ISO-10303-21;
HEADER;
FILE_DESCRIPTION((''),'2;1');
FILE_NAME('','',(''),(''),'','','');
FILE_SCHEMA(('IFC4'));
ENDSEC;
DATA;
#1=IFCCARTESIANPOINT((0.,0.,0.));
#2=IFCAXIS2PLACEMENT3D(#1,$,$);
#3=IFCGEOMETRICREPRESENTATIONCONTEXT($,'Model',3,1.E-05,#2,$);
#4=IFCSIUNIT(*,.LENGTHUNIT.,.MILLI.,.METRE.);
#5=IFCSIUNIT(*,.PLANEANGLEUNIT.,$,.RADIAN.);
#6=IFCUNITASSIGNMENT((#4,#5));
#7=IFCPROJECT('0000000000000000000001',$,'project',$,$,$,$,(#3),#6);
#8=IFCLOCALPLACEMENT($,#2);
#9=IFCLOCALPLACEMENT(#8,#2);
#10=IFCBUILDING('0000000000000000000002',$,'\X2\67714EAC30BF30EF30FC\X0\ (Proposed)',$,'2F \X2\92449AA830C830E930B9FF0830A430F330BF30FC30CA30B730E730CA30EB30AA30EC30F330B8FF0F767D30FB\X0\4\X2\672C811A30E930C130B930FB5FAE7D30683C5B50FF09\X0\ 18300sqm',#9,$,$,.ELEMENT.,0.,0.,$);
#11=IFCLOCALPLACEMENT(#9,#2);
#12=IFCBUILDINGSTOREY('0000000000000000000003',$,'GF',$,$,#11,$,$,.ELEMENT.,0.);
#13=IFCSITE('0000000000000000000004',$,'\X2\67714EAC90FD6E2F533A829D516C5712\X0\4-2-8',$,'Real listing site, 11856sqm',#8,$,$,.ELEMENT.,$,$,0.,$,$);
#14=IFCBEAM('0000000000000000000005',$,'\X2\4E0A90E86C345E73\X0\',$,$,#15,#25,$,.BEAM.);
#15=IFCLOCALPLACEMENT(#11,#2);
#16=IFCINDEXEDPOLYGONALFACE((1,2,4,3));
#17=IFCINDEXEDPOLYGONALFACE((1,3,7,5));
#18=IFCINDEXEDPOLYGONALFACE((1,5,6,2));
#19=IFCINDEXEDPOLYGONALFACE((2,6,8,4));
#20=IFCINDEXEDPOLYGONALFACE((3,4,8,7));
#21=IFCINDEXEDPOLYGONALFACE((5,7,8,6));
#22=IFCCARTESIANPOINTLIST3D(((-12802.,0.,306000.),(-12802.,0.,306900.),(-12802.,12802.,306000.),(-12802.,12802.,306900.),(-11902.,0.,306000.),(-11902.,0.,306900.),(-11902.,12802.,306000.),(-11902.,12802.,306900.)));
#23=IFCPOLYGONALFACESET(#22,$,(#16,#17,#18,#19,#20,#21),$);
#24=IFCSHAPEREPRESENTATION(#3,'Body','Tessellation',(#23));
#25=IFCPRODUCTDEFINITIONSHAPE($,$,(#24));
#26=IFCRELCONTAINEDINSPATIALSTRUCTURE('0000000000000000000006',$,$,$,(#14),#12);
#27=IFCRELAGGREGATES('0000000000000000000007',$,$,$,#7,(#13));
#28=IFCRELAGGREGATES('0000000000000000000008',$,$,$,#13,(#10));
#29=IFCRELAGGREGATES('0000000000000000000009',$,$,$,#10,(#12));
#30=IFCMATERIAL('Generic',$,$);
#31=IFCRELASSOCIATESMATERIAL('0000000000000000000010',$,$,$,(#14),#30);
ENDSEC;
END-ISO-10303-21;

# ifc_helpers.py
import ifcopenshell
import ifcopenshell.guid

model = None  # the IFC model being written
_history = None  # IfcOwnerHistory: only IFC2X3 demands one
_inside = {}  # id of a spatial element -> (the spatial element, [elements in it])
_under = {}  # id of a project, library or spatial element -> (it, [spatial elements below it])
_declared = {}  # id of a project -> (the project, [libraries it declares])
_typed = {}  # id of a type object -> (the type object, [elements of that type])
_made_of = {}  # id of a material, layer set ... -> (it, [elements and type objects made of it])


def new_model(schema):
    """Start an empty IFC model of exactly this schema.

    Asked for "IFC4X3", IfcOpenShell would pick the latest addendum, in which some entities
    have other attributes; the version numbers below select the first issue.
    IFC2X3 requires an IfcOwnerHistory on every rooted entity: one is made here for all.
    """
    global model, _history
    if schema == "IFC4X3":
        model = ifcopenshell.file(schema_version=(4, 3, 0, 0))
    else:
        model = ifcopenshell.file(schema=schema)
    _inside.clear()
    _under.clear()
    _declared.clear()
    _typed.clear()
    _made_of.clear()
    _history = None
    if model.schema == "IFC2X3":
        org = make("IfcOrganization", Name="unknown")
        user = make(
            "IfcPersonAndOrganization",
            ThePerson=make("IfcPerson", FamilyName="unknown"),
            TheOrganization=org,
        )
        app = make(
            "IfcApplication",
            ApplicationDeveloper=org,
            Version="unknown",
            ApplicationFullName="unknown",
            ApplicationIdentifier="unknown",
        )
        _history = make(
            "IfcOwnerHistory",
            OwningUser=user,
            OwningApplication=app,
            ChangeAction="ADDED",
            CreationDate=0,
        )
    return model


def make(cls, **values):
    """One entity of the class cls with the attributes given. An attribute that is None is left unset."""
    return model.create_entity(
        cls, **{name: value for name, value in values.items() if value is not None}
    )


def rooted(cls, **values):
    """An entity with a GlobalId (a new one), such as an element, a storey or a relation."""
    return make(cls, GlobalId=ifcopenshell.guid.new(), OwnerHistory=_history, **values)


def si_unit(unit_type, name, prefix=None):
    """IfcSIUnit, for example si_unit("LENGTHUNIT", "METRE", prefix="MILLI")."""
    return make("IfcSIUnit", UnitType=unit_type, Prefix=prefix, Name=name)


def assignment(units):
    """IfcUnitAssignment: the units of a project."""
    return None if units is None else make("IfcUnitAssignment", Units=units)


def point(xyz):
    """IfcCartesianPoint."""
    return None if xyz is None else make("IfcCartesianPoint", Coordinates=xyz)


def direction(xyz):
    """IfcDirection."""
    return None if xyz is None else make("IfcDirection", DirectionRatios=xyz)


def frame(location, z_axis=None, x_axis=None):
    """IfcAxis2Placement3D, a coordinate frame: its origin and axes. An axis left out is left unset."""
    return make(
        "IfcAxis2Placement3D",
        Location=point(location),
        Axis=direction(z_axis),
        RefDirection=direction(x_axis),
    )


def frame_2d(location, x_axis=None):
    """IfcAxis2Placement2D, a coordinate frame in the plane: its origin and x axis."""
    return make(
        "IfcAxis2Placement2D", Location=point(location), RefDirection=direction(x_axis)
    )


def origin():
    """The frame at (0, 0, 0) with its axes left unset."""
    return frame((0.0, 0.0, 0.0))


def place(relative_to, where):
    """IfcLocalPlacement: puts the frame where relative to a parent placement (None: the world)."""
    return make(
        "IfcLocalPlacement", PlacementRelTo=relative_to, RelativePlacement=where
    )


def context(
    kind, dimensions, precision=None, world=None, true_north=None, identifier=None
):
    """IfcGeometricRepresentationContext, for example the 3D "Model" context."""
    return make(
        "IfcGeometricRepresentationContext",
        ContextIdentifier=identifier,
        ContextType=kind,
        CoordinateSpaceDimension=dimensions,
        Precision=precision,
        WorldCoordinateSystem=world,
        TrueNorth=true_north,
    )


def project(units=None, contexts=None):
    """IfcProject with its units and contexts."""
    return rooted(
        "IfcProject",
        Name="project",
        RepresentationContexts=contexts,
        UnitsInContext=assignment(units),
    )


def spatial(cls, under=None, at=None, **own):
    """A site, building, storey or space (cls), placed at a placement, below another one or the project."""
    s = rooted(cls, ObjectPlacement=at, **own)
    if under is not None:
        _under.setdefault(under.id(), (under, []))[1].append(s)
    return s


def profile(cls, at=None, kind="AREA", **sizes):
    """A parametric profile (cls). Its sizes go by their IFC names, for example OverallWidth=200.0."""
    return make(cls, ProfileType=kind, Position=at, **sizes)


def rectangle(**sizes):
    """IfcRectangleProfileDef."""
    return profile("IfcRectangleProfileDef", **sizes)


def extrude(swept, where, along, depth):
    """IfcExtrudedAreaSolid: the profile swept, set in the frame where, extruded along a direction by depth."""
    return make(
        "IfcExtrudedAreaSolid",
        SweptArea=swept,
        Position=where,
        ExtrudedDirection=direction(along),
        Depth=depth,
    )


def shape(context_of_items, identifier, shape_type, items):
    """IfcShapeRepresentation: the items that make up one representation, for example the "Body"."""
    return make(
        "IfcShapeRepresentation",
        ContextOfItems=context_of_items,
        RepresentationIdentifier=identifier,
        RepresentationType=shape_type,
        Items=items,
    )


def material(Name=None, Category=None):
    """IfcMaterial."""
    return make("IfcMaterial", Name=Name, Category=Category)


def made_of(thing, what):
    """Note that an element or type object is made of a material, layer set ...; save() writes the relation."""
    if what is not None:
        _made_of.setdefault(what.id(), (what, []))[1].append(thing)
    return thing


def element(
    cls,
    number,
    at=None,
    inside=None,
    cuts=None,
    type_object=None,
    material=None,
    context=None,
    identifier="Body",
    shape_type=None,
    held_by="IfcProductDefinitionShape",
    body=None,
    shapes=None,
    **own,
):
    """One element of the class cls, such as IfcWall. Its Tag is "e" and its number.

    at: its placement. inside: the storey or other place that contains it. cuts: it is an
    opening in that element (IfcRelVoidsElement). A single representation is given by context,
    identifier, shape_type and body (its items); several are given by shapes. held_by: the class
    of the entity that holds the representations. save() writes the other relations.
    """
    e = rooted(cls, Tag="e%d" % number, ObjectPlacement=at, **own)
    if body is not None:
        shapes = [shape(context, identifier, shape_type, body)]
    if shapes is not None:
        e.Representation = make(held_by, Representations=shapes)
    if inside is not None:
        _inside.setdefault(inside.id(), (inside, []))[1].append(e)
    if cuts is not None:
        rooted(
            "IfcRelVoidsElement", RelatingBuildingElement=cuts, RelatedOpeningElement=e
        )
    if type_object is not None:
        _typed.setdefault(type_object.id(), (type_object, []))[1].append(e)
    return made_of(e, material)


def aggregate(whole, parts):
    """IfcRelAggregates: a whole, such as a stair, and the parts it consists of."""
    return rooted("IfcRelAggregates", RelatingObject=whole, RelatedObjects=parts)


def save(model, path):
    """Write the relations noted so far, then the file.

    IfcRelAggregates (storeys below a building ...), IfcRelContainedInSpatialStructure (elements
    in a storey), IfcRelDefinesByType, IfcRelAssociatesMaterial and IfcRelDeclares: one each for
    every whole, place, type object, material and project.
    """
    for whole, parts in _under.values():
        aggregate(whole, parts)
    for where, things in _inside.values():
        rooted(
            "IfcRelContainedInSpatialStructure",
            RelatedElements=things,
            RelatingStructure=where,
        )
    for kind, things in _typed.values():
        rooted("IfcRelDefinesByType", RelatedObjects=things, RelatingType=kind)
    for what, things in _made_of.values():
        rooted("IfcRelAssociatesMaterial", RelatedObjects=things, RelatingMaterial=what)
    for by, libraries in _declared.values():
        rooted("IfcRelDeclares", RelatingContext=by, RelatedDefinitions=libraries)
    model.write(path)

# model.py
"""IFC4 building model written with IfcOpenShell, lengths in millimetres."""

from ifc_helpers import new_model, si_unit, frame, frame_2d, origin, place, context, project, spatial, rectangle, extrude, material, element, save


model = new_model("IFC4")

# Units and contexts
model_context = context("Model", 3, precision=1e-05, world=origin())
ifc_project = project(units=[si_unit("LENGTHUNIT", "METRE", prefix="MILLI"), si_unit("PLANEANGLEUNIT", "RADIAN")], contexts=[model_context])

# Site, building, storey
site_placement = place(None, origin())
site = spatial("IfcSite", under=ifc_project, at=site_placement, Name="東京都港区芝公園4-2-8", ObjectType="Real listing site, 11856sqm", CompositionType="ELEMENT", RefElevation=0.0)
building_placement = place(site_placement, origin())
building = spatial("IfcBuilding", under=site, at=building_placement, Name="東京タワー (Proposed)", ObjectType="2F 鉄骨トラス（インターナショナルオレンジ／白・4本脚ラチス・微細格子） 18300sqm", CompositionType="ELEMENT", ElevationOfRefHeight=0.0, ElevationOfTerrain=0.0)
storey_placement = place(building_placement, origin())
storey = spatial("IfcBuildingStorey", under=building, at=storey_placement, Name="GF", CompositionType="ELEMENT", Elevation=0.0)

# Shared definitions
ifc_material = material(Name="Generic")

# Beam
beam_placement = place(storey_placement, frame((-6401.0, 0.0, 153000.0)))
element("IfcBeam", 1, at=beam_placement, inside=storey, material=ifc_material, Name="上部水平", PredefinedType="BEAM", context=model_context, shape_type="SweptSolid", body=[
    extrude(rectangle(XDim=900.0, YDim=12802.0, at=frame_2d((450.0, 6401.0))), frame((-6401.0, 0.0, 153000.0)), (0.0, 0.0, 1.0), 900.0),
])

save(model, "model.ifc")
